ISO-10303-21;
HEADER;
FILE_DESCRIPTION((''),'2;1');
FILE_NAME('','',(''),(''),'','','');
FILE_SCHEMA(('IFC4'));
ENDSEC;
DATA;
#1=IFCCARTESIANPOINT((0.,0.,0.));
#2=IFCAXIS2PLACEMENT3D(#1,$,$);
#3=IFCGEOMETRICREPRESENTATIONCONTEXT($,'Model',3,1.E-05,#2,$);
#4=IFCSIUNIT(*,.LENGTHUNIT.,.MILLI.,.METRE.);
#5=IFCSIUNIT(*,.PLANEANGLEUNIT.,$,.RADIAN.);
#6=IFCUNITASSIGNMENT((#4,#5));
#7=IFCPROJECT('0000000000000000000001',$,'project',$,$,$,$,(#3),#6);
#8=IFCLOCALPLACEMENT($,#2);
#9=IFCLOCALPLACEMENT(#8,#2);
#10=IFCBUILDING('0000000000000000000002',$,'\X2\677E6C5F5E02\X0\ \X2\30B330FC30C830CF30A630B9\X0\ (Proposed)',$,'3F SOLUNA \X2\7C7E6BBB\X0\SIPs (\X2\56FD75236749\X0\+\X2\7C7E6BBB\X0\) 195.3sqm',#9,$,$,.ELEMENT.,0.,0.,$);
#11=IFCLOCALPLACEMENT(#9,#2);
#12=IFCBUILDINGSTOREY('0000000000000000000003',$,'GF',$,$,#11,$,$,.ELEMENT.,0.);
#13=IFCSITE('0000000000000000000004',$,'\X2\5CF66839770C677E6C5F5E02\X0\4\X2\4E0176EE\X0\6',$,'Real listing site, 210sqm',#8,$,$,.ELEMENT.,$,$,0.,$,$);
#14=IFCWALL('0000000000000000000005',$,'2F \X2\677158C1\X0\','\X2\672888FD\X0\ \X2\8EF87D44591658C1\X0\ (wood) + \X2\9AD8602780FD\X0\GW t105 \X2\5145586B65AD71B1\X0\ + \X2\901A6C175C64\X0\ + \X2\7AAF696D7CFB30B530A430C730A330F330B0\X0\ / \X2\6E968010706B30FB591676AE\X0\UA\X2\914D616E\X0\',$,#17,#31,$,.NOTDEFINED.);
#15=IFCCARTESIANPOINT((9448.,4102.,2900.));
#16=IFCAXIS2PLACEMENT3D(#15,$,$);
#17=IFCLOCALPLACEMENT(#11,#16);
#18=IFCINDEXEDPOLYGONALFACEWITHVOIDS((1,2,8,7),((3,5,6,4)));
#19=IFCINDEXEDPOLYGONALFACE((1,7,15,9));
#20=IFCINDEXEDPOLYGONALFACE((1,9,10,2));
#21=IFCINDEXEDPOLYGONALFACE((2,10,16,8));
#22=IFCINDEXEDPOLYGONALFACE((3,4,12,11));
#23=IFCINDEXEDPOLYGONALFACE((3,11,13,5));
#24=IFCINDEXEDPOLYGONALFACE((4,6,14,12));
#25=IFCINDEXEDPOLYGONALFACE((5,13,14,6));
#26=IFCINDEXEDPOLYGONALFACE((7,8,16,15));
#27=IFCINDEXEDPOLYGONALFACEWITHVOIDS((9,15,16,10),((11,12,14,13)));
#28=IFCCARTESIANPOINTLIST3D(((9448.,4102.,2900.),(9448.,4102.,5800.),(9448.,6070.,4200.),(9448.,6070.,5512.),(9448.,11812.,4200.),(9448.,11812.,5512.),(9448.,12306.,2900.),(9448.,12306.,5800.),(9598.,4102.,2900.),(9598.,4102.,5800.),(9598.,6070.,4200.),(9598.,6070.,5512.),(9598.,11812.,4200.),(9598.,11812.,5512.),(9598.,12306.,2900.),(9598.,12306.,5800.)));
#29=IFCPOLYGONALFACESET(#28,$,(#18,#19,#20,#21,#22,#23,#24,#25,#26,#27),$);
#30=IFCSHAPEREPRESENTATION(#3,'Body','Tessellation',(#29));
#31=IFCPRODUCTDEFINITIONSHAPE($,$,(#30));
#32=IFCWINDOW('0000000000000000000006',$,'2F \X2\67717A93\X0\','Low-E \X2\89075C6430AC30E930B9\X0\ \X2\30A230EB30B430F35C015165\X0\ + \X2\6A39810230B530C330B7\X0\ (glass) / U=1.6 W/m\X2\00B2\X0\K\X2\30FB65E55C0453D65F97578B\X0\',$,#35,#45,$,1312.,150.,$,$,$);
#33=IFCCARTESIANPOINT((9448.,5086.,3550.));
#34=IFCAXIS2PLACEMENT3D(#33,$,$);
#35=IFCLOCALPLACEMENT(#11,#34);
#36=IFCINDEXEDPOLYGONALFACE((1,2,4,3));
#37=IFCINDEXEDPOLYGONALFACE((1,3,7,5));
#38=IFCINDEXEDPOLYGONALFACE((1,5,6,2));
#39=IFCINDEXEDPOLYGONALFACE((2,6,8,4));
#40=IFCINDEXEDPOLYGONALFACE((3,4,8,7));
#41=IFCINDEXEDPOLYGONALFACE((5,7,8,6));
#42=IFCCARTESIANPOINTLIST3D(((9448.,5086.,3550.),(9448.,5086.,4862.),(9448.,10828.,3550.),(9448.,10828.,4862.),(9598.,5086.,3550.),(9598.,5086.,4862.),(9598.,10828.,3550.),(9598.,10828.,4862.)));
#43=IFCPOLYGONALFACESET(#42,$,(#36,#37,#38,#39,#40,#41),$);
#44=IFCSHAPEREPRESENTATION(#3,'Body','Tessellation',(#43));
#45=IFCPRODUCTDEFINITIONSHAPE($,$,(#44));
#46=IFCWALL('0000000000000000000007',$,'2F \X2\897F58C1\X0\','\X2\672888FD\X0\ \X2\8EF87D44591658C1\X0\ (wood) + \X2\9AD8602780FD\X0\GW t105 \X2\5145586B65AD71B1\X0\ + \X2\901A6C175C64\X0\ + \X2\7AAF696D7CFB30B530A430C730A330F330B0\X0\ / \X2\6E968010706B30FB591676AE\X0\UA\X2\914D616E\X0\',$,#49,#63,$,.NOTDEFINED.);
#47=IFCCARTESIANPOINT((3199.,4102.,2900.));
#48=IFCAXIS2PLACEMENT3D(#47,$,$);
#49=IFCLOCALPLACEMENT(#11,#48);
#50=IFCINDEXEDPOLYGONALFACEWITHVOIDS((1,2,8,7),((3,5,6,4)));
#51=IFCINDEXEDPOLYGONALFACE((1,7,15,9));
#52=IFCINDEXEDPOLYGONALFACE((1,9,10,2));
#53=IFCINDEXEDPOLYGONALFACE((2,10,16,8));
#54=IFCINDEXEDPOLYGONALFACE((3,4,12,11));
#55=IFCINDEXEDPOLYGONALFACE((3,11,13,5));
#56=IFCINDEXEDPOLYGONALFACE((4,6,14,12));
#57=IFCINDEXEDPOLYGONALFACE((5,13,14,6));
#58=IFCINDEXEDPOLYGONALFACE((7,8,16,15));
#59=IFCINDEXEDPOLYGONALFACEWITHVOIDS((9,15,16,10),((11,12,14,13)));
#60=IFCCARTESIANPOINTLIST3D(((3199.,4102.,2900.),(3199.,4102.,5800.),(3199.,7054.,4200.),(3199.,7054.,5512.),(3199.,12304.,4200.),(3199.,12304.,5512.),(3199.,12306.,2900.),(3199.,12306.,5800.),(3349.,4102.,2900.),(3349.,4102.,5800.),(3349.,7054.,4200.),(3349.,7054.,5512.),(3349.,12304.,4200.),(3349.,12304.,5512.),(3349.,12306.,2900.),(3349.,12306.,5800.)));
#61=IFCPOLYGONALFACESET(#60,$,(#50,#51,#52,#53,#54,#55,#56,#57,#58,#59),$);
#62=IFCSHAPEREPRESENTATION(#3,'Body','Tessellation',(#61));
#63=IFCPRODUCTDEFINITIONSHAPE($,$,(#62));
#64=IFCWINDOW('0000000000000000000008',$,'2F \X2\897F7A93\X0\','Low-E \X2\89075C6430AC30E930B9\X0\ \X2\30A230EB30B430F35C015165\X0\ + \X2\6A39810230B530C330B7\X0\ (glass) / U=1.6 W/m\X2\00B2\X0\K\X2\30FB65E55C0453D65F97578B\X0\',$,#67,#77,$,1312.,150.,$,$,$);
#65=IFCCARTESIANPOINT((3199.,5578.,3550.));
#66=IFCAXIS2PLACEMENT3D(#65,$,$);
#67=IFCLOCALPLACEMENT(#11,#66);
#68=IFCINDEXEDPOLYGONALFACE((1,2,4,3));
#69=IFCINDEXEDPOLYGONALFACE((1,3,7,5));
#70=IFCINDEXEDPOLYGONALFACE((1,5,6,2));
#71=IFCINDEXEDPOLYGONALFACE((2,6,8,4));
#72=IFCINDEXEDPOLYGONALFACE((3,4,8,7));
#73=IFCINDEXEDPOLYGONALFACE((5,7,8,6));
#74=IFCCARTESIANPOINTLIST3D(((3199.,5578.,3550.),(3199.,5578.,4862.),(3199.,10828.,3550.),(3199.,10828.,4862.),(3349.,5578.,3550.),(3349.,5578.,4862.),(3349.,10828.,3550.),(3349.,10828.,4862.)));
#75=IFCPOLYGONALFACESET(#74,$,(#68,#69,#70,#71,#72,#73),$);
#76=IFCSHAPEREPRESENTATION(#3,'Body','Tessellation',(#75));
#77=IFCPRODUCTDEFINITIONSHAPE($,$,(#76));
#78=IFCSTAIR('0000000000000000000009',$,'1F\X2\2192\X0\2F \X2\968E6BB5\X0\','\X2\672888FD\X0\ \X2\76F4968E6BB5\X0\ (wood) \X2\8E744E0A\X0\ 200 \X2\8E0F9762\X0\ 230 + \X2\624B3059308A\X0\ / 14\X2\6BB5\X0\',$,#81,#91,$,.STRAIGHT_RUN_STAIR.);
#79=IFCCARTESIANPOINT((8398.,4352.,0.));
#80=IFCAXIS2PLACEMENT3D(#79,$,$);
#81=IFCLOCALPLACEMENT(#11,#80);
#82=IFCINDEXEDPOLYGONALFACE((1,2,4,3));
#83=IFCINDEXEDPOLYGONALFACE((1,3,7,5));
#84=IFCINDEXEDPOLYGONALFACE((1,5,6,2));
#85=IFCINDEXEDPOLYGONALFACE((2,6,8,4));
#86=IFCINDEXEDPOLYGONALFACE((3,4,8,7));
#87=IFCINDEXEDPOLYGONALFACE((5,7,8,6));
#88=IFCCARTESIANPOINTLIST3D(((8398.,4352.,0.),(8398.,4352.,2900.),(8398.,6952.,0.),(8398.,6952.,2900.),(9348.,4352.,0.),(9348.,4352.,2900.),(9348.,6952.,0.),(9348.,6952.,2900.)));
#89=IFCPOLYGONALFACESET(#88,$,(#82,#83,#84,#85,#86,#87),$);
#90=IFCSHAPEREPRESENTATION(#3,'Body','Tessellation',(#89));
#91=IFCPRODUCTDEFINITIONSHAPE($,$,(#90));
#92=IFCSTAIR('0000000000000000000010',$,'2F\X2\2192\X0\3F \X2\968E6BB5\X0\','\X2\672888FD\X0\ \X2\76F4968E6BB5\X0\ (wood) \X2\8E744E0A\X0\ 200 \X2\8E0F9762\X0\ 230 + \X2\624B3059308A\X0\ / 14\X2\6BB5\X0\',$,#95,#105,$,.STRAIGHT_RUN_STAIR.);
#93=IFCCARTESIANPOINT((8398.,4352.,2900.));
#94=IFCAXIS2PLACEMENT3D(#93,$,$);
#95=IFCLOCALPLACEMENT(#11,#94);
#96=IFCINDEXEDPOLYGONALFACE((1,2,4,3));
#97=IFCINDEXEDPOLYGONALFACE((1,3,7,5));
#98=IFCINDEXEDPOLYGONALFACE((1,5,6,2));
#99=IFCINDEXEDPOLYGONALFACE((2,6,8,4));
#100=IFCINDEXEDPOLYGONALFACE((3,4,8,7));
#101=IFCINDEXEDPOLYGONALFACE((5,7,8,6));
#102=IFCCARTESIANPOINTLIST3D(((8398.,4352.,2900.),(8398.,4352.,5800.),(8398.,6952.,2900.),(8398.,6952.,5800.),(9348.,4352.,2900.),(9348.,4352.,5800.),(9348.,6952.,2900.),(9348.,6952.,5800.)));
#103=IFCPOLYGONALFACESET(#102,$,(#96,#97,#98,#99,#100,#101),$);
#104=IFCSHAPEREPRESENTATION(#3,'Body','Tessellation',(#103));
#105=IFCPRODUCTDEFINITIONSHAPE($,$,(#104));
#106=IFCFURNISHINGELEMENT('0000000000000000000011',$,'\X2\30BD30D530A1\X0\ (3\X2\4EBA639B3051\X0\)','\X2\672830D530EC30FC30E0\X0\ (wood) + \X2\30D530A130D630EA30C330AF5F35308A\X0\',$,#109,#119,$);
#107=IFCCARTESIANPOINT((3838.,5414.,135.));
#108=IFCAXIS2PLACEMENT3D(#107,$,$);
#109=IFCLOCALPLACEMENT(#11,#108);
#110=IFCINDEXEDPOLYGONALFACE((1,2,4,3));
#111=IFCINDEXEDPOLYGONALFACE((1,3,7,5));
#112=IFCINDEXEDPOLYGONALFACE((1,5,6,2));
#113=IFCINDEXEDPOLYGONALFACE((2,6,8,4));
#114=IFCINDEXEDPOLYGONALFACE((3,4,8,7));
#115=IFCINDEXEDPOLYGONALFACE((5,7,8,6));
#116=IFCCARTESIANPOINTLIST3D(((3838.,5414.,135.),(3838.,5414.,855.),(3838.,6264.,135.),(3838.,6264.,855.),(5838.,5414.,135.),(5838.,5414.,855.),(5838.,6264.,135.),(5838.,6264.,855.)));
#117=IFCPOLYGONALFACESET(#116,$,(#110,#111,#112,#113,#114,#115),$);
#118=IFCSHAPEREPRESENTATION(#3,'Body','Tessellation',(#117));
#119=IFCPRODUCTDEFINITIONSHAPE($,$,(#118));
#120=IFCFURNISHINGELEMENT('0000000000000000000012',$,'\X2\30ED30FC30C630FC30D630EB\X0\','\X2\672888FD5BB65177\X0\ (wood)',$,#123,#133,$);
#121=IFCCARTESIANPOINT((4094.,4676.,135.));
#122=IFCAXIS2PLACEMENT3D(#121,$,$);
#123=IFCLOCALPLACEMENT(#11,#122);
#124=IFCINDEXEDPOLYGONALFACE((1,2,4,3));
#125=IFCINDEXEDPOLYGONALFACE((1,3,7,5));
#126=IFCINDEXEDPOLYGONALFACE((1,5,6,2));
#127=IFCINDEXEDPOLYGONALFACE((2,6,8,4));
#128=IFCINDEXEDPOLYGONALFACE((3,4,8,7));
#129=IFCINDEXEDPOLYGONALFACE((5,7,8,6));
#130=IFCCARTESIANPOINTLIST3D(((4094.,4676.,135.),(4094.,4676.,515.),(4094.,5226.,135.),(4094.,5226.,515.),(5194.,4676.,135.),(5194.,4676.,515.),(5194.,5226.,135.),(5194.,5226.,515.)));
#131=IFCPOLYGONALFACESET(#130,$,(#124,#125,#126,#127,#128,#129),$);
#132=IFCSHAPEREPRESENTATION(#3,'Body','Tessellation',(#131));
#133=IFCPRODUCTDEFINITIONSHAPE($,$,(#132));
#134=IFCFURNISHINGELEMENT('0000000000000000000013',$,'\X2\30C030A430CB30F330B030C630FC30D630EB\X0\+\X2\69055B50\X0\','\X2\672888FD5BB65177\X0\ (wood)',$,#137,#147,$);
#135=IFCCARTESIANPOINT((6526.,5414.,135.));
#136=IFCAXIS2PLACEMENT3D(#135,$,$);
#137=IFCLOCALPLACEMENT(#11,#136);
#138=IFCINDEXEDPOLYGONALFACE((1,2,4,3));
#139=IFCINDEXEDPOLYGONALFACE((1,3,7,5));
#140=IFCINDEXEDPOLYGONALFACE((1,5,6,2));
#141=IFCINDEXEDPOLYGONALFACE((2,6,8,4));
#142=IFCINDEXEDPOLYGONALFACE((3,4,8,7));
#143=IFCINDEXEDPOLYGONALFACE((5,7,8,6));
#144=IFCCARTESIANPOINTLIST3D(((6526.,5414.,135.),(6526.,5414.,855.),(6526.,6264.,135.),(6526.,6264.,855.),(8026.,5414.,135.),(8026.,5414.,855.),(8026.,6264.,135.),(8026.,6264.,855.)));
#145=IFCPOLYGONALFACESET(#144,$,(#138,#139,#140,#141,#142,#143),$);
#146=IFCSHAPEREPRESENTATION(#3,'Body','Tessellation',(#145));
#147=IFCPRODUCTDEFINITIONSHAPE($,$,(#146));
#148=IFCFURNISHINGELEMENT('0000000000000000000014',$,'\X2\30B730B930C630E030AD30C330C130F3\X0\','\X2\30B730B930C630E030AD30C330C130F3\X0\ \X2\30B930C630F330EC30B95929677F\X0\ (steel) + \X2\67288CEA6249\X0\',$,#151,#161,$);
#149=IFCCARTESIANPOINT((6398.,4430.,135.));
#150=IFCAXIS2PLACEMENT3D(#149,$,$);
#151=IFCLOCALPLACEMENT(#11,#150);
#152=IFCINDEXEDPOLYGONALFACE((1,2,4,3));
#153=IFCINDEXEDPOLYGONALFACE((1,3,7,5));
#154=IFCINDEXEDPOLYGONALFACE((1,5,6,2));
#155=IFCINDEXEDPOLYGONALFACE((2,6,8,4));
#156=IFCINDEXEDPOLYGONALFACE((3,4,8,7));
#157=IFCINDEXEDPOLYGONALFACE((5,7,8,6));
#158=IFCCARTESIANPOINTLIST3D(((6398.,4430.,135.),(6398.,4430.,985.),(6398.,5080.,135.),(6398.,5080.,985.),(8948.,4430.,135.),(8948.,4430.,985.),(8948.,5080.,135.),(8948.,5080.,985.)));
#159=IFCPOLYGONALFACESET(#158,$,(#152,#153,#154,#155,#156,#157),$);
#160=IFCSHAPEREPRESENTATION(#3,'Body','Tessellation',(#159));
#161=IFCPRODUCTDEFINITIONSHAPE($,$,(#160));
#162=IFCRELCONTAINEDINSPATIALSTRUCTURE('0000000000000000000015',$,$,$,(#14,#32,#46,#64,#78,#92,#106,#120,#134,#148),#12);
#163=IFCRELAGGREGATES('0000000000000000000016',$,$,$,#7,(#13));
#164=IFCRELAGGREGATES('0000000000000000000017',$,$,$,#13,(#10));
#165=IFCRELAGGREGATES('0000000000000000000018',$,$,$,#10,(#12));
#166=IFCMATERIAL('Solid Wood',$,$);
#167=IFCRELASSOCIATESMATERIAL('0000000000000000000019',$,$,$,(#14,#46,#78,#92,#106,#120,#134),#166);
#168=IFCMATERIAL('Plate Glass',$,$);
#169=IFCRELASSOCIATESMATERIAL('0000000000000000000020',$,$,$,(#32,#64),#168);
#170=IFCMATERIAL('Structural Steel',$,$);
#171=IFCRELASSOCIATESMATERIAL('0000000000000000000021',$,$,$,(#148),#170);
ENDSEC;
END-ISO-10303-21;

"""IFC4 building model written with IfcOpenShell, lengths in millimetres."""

from ifc_helpers import new_model, si_unit, frame, frame_2d, origin, place, context, project, spatial, rectangle, extrude, material, element, fill, save


model = new_model("IFC4")

# Units and contexts
model_context = context("Model", 3, precision=1e-05, world=origin())
ifc_project = project(units=[si_unit("LENGTHUNIT", "METRE", prefix="MILLI"), si_unit("PLANEANGLEUNIT", "RADIAN")], contexts=[model_context])

# Site, building, storey
site_placement = place(None, origin())
site = spatial("IfcSite", under=ifc_project, at=site_placement, Name="島根県松江市4丁目6", ObjectType="Real listing site, 210sqm", CompositionType="ELEMENT", RefElevation=0.0)
building_placement = place(site_placement, origin())
building = spatial("IfcBuilding", under=site, at=building_placement, Name="松江市 コートハウス (Proposed)", ObjectType="3F SOLUNA 籾殻SIPs (国産杉+籾殻) 195.3sqm", CompositionType="ELEMENT", ElevationOfRefHeight=0.0, ElevationOfTerrain=0.0)
storey_placement = place(building_placement, origin())
storey = spatial("IfcBuildingStorey", under=building, at=storey_placement, Name="GF", CompositionType="ELEMENT", Elevation=0.0)

# Shared definitions
ifc_material_1 = material(Name="Solid Wood")

# Shared definitions
ifc_material_2 = material(Name="Plate Glass")

# Walls, openings, windows
wall_1_placement = place(storey_placement, frame((9448.0, 4102.0, 2900.0)))
wall_1 = element("IfcWall", 1, at=wall_1_placement, inside=storey, material=ifc_material_1, Name="2F 東壁", Description="木製 軸組外壁 (wood) + 高性能GW t105 充填断熱 + 通気層 + 窯業系サイディング / 準耐火・外皮UA配慮", PredefinedType="NOTDEFINED", context=model_context, shape_type="SweptSolid", body=[
    extrude(rectangle(XDim=150.0, YDim=8204.0, at=frame_2d((75.0, 4102.0))), frame((9448.0, 4102.0, 2900.0)), (0.0, 0.0, 1.0), 2900.0),
])
opening_1_placement = place(storey_placement, frame((9448.0, 5086.0, 3550.0)))
opening_1 = element("IfcOpeningElement", 2, at=opening_1_placement, cuts=wall_1, PredefinedType="NOTDEFINED", context=model_context, shape_type="SweptSolid", body=[
    extrude(rectangle(XDim=150.0, YDim=5742.0, at=frame_2d((75.0, 2871.0))), frame((9448.0, 5086.0, 3550.0)), (0.0, 0.0, 1.0), 1312.0),
])
window_1_placement = place(storey_placement, frame((9448.0, 5086.0, 3550.0)))
window_1 = element("IfcWindow", 3, at=window_1_placement, inside=storey, material=ifc_material_2, Name="2F 東窓", Description="Low-E 複層ガラス アルゴン封入 + 樹脂サッシ (glass) / U=1.6 W/m²K・日射取得型", OverallHeight=1312.0, OverallWidth=150.0, context=model_context, shape_type="SweptSolid", body=[
    extrude(rectangle(XDim=150.0, YDim=5742.0, at=frame_2d((75.0, 2871.0))), frame((9448.0, 5086.0, 3550.0)), (0.0, 0.0, 1.0), 1312.0),
])
fill(opening_1, window_1)
wall_2_placement = place(storey_placement, frame((3199.0, 4102.0, 2900.0)))
wall_2 = element("IfcWall", 4, at=wall_2_placement, inside=storey, material=ifc_material_1, Name="2F 西壁", Description="木製 軸組外壁 (wood) + 高性能GW t105 充填断熱 + 通気層 + 窯業系サイディング / 準耐火・外皮UA配慮", PredefinedType="NOTDEFINED", context=model_context, shape_type="SweptSolid", body=[
    extrude(rectangle(XDim=150.0, YDim=8204.0, at=frame_2d((75.0, 4102.0))), frame((3199.0, 4102.0, 2900.0)), (0.0, 0.0, 1.0), 2900.0),
])
opening_2_placement = place(storey_placement, frame((3199.0, 5578.0, 3550.0)))
opening_2 = element("IfcOpeningElement", 5, at=opening_2_placement, cuts=wall_2, PredefinedType="NOTDEFINED", context=model_context, shape_type="SweptSolid", body=[
    extrude(rectangle(XDim=150.0, YDim=5250.0, at=frame_2d((75.0, 2625.0))), frame((3199.0, 5578.0, 3550.0)), (0.0, 0.0, 1.0), 1312.0),
])
window_2_placement = place(storey_placement, frame((3199.0, 5578.0, 3550.0)))
window_2 = element("IfcWindow", 6, at=window_2_placement, inside=storey, material=ifc_material_2, Name="2F 西窓", Description="Low-E 複層ガラス アルゴン封入 + 樹脂サッシ (glass) / U=1.6 W/m²K・日射取得型", OverallHeight=1312.0, OverallWidth=150.0, context=model_context, shape_type="SweptSolid", body=[
    extrude(rectangle(XDim=150.0, YDim=5250.0, at=frame_2d((75.0, 2625.0))), frame((3199.0, 5578.0, 3550.0)), (0.0, 0.0, 1.0), 1312.0),
])
fill(opening_2, window_2)

# Stairs
stair_1_placement = place(storey_placement, frame((8398.0, 4352.0, 0.0)))
element("IfcStair", 7, at=stair_1_placement, inside=storey, material=ifc_material_1, Name="1F→2F 階段", Description="木製 直階段 (wood) 蹴上 200 踏面 230 + 手すり / 14段", PredefinedType="STRAIGHT_RUN_STAIR", context=model_context, shape_type="SweptSolid", body=[
    extrude(rectangle(XDim=950.0, YDim=2600.0, at=frame_2d((475.0, 1300.0))), frame((8398.0, 4352.0, 0.0)), (0.0, 0.0, 1.0), 2900.0),
])
stair_2_placement = place(storey_placement, frame((8398.0, 4352.0, 2900.0)))
element("IfcStair", 8, at=stair_2_placement, inside=storey, material=ifc_material_1, Name="2F→3F 階段", Description="木製 直階段 (wood) 蹴上 200 踏面 230 + 手すり / 14段", PredefinedType="STRAIGHT_RUN_STAIR", context=model_context, shape_type="SweptSolid", body=[
    extrude(rectangle(XDim=950.0, YDim=2600.0, at=frame_2d((475.0, 1300.0))), frame((8398.0, 4352.0, 2900.0)), (0.0, 0.0, 1.0), 2900.0),
])

# Furnishing elements
furnishing_1_placement = place(storey_placement, frame((3838.0, 5414.0, 135.0)))
element("IfcFurnishingElement", 9, at=furnishing_1_placement, inside=storey, material=ifc_material_1, Name="ソファ (3人掛け)", Description="木フレーム (wood) + ファブリック張り", context=model_context, shape_type="SweptSolid", body=[
    extrude(rectangle(XDim=2000.0, YDim=850.0, at=frame_2d((1000.0, 425.0))), frame((3838.0, 5414.0, 135.0)), (0.0, 0.0, 1.0), 720.0),
])
furnishing_2_placement = place(storey_placement, frame((4094.0, 4676.0, 135.0)))
element("IfcFurnishingElement", 10, at=furnishing_2_placement, inside=storey, material=ifc_material_1, Name="ローテーブル", Description="木製家具 (wood)", context=model_context, shape_type="SweptSolid", body=[
    extrude(rectangle(XDim=1100.0, YDim=550.0, at=frame_2d((550.0, 275.0))), frame((4094.0, 4676.0, 135.0)), (0.0, 0.0, 1.0), 380.0),
])
furnishing_3_placement = place(storey_placement, frame((6526.0, 5414.0, 135.0)))
element("IfcFurnishingElement", 11, at=furnishing_3_placement, inside=storey, material=ifc_material_1, Name="ダイニングテーブル+椅子", Description="木製家具 (wood)", context=model_context, shape_type="SweptSolid", body=[
    extrude(rectangle(XDim=1500.0, YDim=850.0, at=frame_2d((750.0, 425.0))), frame((6526.0, 5414.0, 135.0)), (0.0, 0.0, 1.0), 720.0),
])
ifc_material_3 = material(Name="Structural Steel")
furnishing_4_placement = place(storey_placement, frame((6398.0, 4430.0, 135.0)))
element("IfcFurnishingElement", 12, at=furnishing_4_placement, inside=storey, material=ifc_material_3, Name="システムキッチン", Description="システムキッチン ステンレス天板 (steel) + 木質扉", context=model_context, shape_type="SweptSolid", body=[
    extrude(rectangle(XDim=2550.0, YDim=650.0, at=frame_2d((1275.0, 325.0))), frame((6398.0, 4430.0, 135.0)), (0.0, 0.0, 1.0), 850.0),
])

save(model, "model.ifc")
